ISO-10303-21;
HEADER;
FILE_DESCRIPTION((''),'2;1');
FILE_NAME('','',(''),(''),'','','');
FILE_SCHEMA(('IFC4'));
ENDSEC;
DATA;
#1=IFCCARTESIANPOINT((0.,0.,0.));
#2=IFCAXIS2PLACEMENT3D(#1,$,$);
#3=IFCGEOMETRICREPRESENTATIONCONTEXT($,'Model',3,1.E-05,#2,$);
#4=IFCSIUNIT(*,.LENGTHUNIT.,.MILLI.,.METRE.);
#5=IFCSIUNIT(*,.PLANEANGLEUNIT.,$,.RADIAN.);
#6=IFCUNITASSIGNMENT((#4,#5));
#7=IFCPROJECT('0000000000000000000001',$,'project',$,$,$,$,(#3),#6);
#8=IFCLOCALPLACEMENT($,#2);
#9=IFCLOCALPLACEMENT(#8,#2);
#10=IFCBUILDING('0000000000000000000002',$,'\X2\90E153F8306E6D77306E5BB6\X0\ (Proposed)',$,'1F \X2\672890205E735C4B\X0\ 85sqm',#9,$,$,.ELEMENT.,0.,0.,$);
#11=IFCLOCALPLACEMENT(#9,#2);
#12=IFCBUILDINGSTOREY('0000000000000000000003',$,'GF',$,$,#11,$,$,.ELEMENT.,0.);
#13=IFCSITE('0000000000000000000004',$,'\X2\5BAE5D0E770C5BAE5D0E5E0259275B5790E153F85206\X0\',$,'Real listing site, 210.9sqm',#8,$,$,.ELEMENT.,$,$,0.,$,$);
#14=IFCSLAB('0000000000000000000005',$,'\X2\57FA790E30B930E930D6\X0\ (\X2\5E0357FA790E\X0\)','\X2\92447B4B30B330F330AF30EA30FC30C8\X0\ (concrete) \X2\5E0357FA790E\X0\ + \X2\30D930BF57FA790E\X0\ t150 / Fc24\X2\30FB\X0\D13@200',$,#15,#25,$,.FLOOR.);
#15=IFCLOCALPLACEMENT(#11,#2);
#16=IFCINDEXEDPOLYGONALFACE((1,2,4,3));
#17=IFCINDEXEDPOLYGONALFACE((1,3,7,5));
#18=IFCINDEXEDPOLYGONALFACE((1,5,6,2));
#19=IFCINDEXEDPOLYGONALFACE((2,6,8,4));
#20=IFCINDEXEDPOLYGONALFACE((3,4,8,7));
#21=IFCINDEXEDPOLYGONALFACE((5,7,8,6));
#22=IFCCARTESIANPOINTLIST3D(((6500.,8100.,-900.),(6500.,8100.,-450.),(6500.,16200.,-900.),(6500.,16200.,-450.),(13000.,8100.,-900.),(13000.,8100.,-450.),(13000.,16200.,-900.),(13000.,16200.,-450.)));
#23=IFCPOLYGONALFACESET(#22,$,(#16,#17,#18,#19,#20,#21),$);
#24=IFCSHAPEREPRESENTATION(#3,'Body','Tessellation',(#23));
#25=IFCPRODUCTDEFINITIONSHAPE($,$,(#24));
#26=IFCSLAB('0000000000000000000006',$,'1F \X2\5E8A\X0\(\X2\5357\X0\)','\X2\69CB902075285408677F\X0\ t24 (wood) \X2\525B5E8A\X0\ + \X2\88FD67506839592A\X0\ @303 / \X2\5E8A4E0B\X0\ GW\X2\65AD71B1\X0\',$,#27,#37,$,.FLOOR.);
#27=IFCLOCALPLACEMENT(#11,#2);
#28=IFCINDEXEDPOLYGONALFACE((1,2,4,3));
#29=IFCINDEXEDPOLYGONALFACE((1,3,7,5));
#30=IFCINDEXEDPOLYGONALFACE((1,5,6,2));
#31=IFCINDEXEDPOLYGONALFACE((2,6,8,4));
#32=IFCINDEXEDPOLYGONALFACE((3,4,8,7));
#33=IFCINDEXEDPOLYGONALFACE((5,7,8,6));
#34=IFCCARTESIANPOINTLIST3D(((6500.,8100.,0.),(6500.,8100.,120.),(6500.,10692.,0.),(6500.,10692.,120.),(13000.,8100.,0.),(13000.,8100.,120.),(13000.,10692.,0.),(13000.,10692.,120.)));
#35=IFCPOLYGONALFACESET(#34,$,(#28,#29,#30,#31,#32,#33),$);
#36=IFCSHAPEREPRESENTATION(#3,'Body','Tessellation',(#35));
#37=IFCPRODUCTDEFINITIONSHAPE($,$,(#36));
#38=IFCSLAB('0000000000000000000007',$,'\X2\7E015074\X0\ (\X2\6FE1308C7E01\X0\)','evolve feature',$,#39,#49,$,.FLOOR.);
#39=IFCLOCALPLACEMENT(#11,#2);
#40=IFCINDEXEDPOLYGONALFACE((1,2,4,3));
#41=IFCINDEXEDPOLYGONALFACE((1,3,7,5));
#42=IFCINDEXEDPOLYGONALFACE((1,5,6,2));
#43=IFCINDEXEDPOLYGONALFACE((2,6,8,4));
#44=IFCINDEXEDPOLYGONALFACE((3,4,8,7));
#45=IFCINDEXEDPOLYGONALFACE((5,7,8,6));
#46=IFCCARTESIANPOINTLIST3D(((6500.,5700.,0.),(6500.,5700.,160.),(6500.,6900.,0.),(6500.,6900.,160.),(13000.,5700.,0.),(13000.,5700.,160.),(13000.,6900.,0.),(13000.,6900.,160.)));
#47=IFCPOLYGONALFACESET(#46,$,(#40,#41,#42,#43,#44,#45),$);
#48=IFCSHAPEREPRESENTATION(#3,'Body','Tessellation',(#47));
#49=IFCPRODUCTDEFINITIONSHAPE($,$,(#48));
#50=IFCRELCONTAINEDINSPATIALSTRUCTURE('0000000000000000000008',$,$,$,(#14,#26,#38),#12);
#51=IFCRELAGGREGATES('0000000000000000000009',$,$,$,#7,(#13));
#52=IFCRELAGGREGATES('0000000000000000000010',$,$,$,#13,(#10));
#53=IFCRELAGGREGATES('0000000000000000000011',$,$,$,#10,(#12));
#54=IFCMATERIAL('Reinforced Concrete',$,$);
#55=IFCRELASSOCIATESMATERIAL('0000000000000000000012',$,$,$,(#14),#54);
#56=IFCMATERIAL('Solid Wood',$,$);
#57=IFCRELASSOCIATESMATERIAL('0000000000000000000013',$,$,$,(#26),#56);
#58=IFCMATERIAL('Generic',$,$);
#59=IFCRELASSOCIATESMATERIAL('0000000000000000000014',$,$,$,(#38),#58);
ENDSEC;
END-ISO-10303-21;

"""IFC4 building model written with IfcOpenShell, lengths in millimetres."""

from ifc_helpers import new_model, si_unit, frame, frame_2d, origin, place, context, project, spatial, rectangle, extrude, material, element, save


model = new_model("IFC4")

# Units and contexts
model_context = context("Model", 3, precision=1e-05, world=origin())
ifc_project = project(units=[si_unit("LENGTHUNIT", "METRE", prefix="MILLI"), si_unit("PLANEANGLEUNIT", "RADIAN")], contexts=[model_context])

# Site, building, storey
site_placement = place(None, origin())
site = spatial("IfcSite", under=ifc_project, at=site_placement, Name="宮崎県宮崎市大字郡司分", ObjectType="Real listing site, 210.9sqm", CompositionType="ELEMENT", RefElevation=0.0)
building_placement = place(site_placement, origin())
building = spatial("IfcBuilding", under=site, at=building_placement, Name="郡司の海の家 (Proposed)", ObjectType="1F 木造平屋 85sqm", CompositionType="ELEMENT", ElevationOfRefHeight=0.0, ElevationOfTerrain=0.0)
storey_placement = place(building_placement, origin())
storey = spatial("IfcBuildingStorey", under=building, at=storey_placement, Name="GF", CompositionType="ELEMENT", Elevation=0.0)

# Slabs
ifc_material_1 = material(Name="Reinforced Concrete")
slab_1_placement = place(storey_placement, frame((3250.0, 4050.0, -450.0)))
element("IfcSlab", 1, at=slab_1_placement, inside=storey, material=ifc_material_1, Name="基礎スラブ (布基礎)", Description="鉄筋コンクリート (concrete) 布基礎 + ベタ基礎 t150 / Fc24・D13@200", PredefinedType="FLOOR", context=model_context, shape_type="SweptSolid", body=[
    extrude(rectangle(XDim=6500.0, YDim=8100.0, at=frame_2d((3250.0, 4050.0))), frame((3250.0, 4050.0, -450.0)), (0.0, 0.0, 1.0), 450.0),
])
ifc_material_2 = material(Name="Solid Wood")
slab_2_placement = place(storey_placement, frame((3250.0, 4050.0, 0.0)))
element("IfcSlab", 2, at=slab_2_placement, inside=storey, material=ifc_material_2, Name="1F 床(南)", Description="構造用合板 t24 (wood) 剛床 + 製材根太 @303 / 床下 GW断熱", PredefinedType="FLOOR", context=model_context, shape_type="SweptSolid", body=[
    extrude(rectangle(XDim=6500.0, YDim=2592.0, at=frame_2d((3250.0, 1296.0))), frame((3250.0, 4050.0, 0.0)), (0.0, 0.0, 1.0), 120.0),
])
ifc_material_3 = material(Name="Generic")
slab_3_placement = place(storey_placement, frame((3250.0, 2850.0, 0.0)))
element("IfcSlab", 3, at=slab_3_placement, inside=storey, material=ifc_material_3, Name="縁側 (濡れ縁)", Description="evolve feature", PredefinedType="FLOOR", context=model_context, shape_type="SweptSolid", body=[
    extrude(rectangle(XDim=6500.0, YDim=1200.0, at=frame_2d((3250.0, 600.0))), frame((3250.0, 2850.0, 0.0)), (0.0, 0.0, 1.0), 160.0),
])

save(model, "model.ifc")
